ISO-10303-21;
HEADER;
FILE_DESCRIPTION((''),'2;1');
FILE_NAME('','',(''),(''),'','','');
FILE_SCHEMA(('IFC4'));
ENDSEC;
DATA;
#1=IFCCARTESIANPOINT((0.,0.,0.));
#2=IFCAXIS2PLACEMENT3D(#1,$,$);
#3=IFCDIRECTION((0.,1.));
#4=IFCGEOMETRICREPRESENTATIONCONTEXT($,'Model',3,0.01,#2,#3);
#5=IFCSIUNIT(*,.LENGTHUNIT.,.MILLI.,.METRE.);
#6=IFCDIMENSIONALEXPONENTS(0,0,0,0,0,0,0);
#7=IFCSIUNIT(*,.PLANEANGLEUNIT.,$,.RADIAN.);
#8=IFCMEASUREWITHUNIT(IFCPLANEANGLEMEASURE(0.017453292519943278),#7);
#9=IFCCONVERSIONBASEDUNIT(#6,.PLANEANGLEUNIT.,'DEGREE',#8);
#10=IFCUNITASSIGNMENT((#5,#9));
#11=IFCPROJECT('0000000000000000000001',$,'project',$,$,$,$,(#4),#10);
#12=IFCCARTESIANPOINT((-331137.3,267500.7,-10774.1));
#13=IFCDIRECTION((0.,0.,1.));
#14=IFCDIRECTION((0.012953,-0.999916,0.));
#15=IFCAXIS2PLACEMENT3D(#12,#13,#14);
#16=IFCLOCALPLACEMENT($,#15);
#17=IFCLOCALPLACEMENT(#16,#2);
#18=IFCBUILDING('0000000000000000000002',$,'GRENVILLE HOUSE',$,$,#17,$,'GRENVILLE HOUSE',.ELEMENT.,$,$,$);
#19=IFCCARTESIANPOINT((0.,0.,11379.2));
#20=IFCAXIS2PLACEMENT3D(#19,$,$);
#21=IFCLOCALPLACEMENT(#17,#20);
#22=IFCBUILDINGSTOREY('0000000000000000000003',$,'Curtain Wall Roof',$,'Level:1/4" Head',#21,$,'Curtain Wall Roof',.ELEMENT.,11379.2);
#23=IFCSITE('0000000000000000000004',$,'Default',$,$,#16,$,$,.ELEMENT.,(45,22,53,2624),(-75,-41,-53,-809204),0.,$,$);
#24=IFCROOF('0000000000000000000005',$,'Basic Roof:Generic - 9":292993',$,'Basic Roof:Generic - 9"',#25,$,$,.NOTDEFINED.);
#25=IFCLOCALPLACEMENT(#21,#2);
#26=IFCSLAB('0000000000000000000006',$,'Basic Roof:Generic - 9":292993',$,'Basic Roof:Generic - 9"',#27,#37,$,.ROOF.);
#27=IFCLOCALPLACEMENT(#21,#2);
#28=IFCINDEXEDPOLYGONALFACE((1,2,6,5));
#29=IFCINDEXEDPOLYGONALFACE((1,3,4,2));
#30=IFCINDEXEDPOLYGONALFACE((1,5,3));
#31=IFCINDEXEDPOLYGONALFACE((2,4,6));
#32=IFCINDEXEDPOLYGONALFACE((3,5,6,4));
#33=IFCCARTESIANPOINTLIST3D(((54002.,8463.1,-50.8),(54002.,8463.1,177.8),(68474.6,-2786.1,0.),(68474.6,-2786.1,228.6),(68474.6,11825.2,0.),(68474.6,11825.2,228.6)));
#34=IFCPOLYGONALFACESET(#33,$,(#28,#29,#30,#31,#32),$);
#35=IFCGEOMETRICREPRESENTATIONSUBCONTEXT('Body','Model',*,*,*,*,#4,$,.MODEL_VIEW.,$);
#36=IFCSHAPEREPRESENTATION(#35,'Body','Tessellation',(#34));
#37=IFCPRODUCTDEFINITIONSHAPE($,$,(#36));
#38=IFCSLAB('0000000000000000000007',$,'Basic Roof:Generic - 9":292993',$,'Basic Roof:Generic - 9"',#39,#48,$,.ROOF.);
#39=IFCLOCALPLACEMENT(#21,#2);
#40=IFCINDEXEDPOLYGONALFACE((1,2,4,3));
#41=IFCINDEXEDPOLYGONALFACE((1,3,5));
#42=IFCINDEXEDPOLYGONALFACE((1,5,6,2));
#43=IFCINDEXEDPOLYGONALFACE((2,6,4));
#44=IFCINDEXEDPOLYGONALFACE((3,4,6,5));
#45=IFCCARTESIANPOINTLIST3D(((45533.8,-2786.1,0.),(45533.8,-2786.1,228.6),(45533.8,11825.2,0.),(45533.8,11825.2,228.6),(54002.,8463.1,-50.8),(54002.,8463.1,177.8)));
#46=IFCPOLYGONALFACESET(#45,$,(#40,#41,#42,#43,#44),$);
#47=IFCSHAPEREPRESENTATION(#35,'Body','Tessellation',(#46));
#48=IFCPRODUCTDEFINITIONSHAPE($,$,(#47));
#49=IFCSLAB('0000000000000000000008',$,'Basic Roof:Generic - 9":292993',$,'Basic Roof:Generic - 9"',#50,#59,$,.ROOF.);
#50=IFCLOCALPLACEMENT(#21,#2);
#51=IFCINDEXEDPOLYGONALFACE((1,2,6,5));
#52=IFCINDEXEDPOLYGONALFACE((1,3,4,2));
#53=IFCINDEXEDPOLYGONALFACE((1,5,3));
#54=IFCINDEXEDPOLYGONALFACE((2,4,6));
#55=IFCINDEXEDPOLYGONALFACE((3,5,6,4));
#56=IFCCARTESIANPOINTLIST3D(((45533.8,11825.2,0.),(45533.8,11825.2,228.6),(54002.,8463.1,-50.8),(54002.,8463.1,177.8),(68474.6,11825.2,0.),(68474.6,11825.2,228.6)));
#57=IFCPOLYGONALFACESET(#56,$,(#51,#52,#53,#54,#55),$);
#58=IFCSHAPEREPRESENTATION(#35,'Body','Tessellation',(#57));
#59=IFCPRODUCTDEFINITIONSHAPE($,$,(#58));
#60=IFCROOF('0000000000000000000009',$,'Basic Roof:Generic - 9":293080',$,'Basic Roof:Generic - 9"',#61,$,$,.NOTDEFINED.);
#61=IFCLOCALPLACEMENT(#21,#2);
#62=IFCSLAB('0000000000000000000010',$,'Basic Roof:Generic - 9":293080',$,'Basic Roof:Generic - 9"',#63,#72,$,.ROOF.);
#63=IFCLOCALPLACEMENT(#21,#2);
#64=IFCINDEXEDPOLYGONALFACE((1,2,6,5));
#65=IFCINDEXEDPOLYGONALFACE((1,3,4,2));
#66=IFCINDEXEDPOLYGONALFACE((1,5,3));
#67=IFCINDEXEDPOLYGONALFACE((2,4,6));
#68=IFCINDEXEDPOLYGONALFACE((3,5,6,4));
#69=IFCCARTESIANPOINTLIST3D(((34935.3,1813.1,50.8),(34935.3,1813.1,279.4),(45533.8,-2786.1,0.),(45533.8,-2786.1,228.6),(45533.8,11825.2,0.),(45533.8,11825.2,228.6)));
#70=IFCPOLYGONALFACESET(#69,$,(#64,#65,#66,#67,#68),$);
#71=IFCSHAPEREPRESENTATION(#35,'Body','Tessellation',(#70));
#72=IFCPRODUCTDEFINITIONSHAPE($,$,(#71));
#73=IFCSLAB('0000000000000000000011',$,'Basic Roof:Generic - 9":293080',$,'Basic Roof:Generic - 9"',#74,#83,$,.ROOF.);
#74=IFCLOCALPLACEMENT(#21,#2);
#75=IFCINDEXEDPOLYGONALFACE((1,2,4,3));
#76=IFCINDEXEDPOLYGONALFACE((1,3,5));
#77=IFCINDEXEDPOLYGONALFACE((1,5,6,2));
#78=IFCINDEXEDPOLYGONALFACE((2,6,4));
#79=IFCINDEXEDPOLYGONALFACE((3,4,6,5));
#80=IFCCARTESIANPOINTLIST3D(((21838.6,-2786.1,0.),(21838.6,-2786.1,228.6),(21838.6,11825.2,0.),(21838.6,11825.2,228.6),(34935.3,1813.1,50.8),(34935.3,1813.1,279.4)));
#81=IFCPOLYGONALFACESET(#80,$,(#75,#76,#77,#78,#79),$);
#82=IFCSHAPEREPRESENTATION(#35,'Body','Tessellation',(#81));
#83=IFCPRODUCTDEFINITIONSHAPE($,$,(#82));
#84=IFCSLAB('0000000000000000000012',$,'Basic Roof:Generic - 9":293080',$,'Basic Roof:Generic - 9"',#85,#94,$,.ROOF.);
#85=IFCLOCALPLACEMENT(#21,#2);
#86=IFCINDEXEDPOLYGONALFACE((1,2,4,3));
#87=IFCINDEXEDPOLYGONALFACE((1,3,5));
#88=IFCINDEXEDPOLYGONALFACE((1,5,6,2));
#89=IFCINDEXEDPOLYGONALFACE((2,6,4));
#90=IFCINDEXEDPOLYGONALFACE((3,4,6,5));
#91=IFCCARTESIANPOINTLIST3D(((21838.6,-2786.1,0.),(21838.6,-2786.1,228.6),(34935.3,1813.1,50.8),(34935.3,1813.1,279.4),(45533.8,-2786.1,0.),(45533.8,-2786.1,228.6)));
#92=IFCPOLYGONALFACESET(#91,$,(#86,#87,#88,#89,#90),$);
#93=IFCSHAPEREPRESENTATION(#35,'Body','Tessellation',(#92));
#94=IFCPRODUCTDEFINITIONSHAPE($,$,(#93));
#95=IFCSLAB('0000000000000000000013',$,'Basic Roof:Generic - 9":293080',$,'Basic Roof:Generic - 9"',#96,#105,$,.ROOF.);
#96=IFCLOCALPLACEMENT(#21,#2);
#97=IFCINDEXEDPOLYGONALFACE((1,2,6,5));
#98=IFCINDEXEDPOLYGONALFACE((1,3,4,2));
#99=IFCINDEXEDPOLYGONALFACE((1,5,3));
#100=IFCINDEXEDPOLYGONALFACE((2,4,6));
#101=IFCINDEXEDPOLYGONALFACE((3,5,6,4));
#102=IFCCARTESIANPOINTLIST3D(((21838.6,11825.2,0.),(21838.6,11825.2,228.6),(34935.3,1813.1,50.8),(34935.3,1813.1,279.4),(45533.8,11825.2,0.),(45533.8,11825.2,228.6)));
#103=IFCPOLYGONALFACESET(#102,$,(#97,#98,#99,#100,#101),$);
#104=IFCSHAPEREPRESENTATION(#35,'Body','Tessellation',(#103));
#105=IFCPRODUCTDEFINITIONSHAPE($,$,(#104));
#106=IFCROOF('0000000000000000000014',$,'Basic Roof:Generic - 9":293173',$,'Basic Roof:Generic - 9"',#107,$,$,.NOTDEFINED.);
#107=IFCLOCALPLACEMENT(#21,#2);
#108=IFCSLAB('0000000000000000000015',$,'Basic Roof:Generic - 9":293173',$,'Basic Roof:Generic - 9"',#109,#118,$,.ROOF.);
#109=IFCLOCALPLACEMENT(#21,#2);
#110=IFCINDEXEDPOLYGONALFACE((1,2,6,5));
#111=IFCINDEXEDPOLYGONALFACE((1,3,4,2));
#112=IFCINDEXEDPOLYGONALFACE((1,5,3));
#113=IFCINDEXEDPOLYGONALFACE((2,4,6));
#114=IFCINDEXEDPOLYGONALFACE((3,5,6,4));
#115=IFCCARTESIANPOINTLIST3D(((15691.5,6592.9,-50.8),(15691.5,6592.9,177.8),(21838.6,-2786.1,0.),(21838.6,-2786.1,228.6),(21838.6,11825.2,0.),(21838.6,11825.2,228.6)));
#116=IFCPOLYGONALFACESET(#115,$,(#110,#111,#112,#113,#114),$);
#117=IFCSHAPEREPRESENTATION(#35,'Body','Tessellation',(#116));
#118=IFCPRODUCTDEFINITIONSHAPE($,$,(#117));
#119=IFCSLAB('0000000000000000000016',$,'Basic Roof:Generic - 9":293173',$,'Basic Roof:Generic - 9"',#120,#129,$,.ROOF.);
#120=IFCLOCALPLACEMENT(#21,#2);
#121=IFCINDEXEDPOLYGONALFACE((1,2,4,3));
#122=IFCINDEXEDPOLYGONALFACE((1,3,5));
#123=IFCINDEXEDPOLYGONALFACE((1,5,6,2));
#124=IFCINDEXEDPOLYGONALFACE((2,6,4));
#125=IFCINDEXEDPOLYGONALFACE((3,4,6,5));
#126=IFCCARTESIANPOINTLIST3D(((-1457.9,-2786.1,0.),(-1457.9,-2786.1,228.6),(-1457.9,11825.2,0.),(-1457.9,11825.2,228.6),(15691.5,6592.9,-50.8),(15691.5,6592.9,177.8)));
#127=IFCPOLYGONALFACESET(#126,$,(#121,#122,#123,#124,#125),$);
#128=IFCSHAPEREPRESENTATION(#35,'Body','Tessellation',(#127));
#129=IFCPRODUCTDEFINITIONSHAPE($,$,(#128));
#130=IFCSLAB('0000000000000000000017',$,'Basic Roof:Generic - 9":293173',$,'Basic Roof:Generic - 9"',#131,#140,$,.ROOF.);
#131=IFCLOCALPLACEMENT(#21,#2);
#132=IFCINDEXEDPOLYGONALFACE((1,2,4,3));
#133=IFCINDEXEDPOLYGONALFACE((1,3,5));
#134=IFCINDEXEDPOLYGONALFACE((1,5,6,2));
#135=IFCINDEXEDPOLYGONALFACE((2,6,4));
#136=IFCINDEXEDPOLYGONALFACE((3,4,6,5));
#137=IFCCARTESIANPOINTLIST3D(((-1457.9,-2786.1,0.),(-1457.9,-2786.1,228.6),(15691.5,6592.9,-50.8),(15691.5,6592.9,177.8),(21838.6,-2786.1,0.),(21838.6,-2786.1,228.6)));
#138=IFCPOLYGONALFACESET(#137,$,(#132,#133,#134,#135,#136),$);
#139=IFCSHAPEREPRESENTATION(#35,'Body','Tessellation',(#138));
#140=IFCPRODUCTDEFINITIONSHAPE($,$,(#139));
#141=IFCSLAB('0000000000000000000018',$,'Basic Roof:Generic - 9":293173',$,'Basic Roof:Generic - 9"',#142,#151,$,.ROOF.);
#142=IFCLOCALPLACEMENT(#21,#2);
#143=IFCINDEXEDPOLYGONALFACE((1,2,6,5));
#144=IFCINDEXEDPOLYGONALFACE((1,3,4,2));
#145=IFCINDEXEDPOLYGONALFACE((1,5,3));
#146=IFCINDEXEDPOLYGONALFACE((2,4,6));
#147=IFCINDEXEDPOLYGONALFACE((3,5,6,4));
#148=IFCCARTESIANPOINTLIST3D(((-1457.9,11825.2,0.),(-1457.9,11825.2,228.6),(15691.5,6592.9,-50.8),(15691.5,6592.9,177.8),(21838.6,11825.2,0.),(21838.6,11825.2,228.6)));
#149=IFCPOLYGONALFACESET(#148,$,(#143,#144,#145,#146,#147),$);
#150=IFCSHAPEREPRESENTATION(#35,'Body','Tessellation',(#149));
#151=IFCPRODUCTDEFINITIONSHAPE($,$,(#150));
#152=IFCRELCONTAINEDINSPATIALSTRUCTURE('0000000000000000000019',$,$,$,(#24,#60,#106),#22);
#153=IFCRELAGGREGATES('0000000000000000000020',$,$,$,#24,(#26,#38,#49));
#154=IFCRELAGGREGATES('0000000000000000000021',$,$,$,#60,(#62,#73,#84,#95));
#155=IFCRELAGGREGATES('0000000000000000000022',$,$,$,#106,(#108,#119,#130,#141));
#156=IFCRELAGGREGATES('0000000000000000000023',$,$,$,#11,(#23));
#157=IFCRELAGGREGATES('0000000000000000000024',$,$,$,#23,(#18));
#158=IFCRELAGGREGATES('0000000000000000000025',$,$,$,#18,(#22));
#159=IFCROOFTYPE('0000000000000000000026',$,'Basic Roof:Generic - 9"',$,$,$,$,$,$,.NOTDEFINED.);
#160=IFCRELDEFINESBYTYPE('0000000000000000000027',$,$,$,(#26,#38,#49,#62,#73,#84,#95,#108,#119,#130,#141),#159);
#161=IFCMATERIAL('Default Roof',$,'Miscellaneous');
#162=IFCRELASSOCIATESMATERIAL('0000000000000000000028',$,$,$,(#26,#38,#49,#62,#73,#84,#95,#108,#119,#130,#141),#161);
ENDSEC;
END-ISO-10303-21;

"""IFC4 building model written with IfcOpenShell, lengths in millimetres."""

from ifc_helpers import new_model, entity, si_unit, converted_unit, direction, frame, origin, place, context, subcontext, project, spatial, indexed_curve, outline, extrude, material, type_object, element, aggregate, save


model = new_model("IFC4")

# Units and contexts
model_context = context("Model", 3, precision=0.01, world=origin(), true_north=direction((0.0, 1.0)))
body_context = subcontext(model_context, "Body", "Model", "MODEL_VIEW")
ifc_project = project(units=[si_unit("LENGTHUNIT", "METRE", prefix="MILLI"), converted_unit("PLANEANGLEUNIT", "DEGREE", entity("IfcPlaneAngleMeasure", 0.017453292519943278), si_unit("PLANEANGLEUNIT", "RADIAN"), dimensions=[0, 0, 0, 0, 0, 0, 0])], contexts=[model_context])

# Site, building, storey
site_placement = place(None, frame((-331137.3, 267500.7, -10774.1), z_axis=(0.0, 0.0, 1.0), x_axis=(0.012953, -0.999916, 0.0)))
site = spatial("IfcSite", under=ifc_project, at=site_placement, Name="Default", CompositionType="ELEMENT", RefLatitude=(45, 22, 53, 2624), RefLongitude=(-75, -41, -53, -809204), RefElevation=0.0)
building_placement = place(site_placement, origin())
building = spatial("IfcBuilding", under=site, at=building_placement, Name="GRENVILLE HOUSE", LongName="GRENVILLE HOUSE", CompositionType="ELEMENT")
storey_placement = place(building_placement, frame((0.0, 0.0, 11379.2)))
storey = spatial("IfcBuildingStorey", under=building, at=storey_placement, Name="Curtain Wall Roof", ObjectType="Level:1/4\" Head", LongName="Curtain Wall Roof", CompositionType="ELEMENT", Elevation=11379.2)

# Roofs, slabs
roof_1_placement = place(storey_placement, frame((45533.8, -2786.1, -50.8)))
roof_1 = element("IfcRoof", 1, at=roof_1_placement, inside=storey, Name="Basic Roof:Generic - 9\":292993", ObjectType="Basic Roof:Generic - 9\"", PredefinedType="NOTDEFINED")
ifc_material = material(Name="Default Roof", Category="Miscellaneous")
roof_type = type_object("IfcRoofType", Name="Basic Roof:Generic - 9\"", PredefinedType="NOTDEFINED")
slab_1_placement = place(roof_1_placement, origin())
slab_1 = element("IfcSlab", 2, at=slab_1_placement, type_object=roof_type, material=ifc_material, Name="Basic Roof:Generic - 9\":292993", ObjectType="Basic Roof:Generic - 9\"", PredefinedType="ROOF", context=body_context, shape_type="SweptSolid", body=[
    extrude(outline(indexed_curve([(7236.4, -7305.7), (7236.4, 7305.7), (-7236.4, 3943.6), (7236.4, -7305.7)], self_intersect=False)), frame((15704.5, 7305.7, 25.4), z_axis=(-0.00351, 0.0, 0.999994), x_axis=(0.999994, 0.0, 0.00351)), (0.00351, 0.0, 0.999994), 228.6),
])
slab_2_placement = place(roof_1_placement, origin())
slab_2 = element("IfcSlab", 3, at=slab_2_placement, type_object=roof_type, material=ifc_material, Name="Basic Roof:Generic - 9\":292993", ObjectType="Basic Roof:Generic - 9\"", PredefinedType="ROOF", context=body_context, shape_type="SweptSolid", body=[
    extrude(outline(indexed_curve([(-4234.1, 7305.7), (-4234.1, -7305.7), (4234.1, 3943.6), (-4234.1, 7305.7)], self_intersect=False)), frame((4234.1, 7305.7, 25.4), z_axis=(0.005999, 0.0, 0.999982), x_axis=(0.999982, 0.0, -0.005999)), (-0.005999, 0.0, 0.999982), 228.6),
])
slab_3_placement = place(roof_1_placement, origin())
slab_3 = element("IfcSlab", 4, at=slab_3_placement, type_object=roof_type, material=ifc_material, Name="Basic Roof:Generic - 9\":292993", ObjectType="Basic Roof:Generic - 9\"", PredefinedType="ROOF", context=body_context, shape_type="SweptSolid", body=[
    extrude(outline(indexed_curve([(11470.4, 1681.2), (-11470.4, 1681.2), (-3002.2, -1681.2), (11470.4, 1681.2)], self_intersect=False)), frame((11470.4, 12930.3, 25.4), z_axis=(0.0, -0.015108, 0.999886), x_axis=(1.0, 0.0, 0.0)), (0.0, 0.015108, 0.999886), 228.6),
])
aggregate(roof_1, [slab_1, slab_2, slab_3])
roof_2_placement = place(storey_placement, frame((21838.6, -2786.1, 0.0)))
roof_2 = element("IfcRoof", 5, at=roof_2_placement, inside=storey, Name="Basic Roof:Generic - 9\":293080", ObjectType="Basic Roof:Generic - 9\"", PredefinedType="NOTDEFINED")
slab_4_placement = place(roof_2_placement, origin())
slab_4 = element("IfcSlab", 6, at=slab_4_placement, type_object=roof_type, material=ifc_material, Name="Basic Roof:Generic - 9\":293080", ObjectType="Basic Roof:Generic - 9\"", PredefinedType="ROOF", context=body_context, shape_type="SweptSolid", body=[
    extrude(outline(indexed_curve([(5299.3, -7305.7), (5299.3, 7305.7), (-5299.3, -2706.4), (5299.3, -7305.7)], self_intersect=False)), frame((18395.9, 7305.7, 25.4), z_axis=(0.004793, 0.0, 0.999989), x_axis=(0.999989, 0.0, -0.004793)), (-0.004793, 0.0, 0.999989), 228.6),
])
slab_5_placement = place(roof_2_placement, origin())
slab_5 = element("IfcSlab", 7, at=slab_5_placement, type_object=roof_type, material=ifc_material, Name="Basic Roof:Generic - 9\":293080", ObjectType="Basic Roof:Generic - 9\"", PredefinedType="ROOF", context=body_context, shape_type="SweptSolid", body=[
    extrude(outline(indexed_curve([(-6548.4, 7305.7), (-6548.4, -7305.7), (6548.4, -2706.4), (-6548.4, 7305.7)], self_intersect=False)), frame((6548.3, 7305.7, 25.4), z_axis=(-0.003879, 0.0, 0.999992), x_axis=(0.999992, 0.0, 0.003879)), (0.003879, 0.0, 0.999992), 228.6),
])
slab_6_placement = place(roof_2_placement, origin())
slab_6 = element("IfcSlab", 8, at=slab_6_placement, type_object=roof_type, material=ifc_material, Name="Basic Roof:Generic - 9\":293080", ObjectType="Basic Roof:Generic - 9\"", PredefinedType="ROOF", context=body_context, shape_type="SweptSolid", body=[
    extrude(outline(indexed_curve([(11847.6, 0.0), (1249.1, 4599.5), (-11847.6, 0.0), (11847.6, 0.0)], self_intersect=False)), frame((11847.6, 0.0, 0.0), z_axis=(0.0, -0.011045, 0.999939), x_axis=(1.0, 0.0, 0.0)), (0.0, 0.011045, 0.999939), 228.6),
])
slab_7_placement = place(roof_2_placement, origin())
slab_7 = element("IfcSlab", 9, at=slab_7_placement, type_object=roof_type, material=ifc_material, Name="Basic Roof:Generic - 9\":293080", ObjectType="Basic Roof:Generic - 9\"", PredefinedType="ROOF", context=body_context, shape_type="SweptSolid", body=[
    extrude(outline(indexed_curve([(11847.6, 5006.1), (-11847.6, 5006.1), (1249.1, -5006.1), (11847.6, 5006.1)], self_intersect=False)), frame((11847.6, 9605.3, 25.4), z_axis=(0.0, 0.005074, 0.999987), x_axis=(1.0, 0.0, 0.0)), (0.0, -0.005074, 0.999987), 228.6),
])
aggregate(roof_2, [slab_4, slab_5, slab_6, slab_7])
roof_3_placement = place(storey_placement, frame((-1457.9, -2786.1, -50.8)))
roof_3 = element("IfcRoof", 10, at=roof_3_placement, inside=storey, Name="Basic Roof:Generic - 9\":293173", ObjectType="Basic Roof:Generic - 9\"", PredefinedType="NOTDEFINED")
slab_8_placement = place(roof_3_placement, origin())
slab_8 = element("IfcSlab", 11, at=slab_8_placement, type_object=roof_type, material=ifc_material, Name="Basic Roof:Generic - 9\":293173", ObjectType="Basic Roof:Generic - 9\"", PredefinedType="ROOF", context=body_context, shape_type="SweptSolid", body=[
    extrude(outline(indexed_curve([(3073.7, -7305.7), (3073.7, 7305.7), (-3073.7, 2073.4), (3073.7, -7305.7)], self_intersect=False)), frame((20223.0, 7305.7, 25.4), z_axis=(-0.008264, 0.0, 0.999966), x_axis=(0.999966, 0.0, 0.008264)), (0.008264, 0.0, 0.999966), 228.6),
])
slab_9_placement = place(roof_3_placement, origin())
slab_9 = element("IfcSlab", 12, at=slab_9_placement, type_object=roof_type, material=ifc_material, Name="Basic Roof:Generic - 9\":293173", ObjectType="Basic Roof:Generic - 9\"", PredefinedType="ROOF", context=body_context, shape_type="SweptSolid", body=[
    extrude(outline(indexed_curve([(-8574.7, 7305.7), (-8574.7, -7305.7), (8574.7, 2073.4), (-8574.7, 7305.7)], self_intersect=False)), frame((8574.7, 7305.7, 25.4), z_axis=(0.002962, 0.0, 0.999996), x_axis=(0.999996, 0.0, -0.002962)), (-0.002962, 0.0, 0.999996), 228.6),
])
slab_10_placement = place(roof_3_placement, origin())
slab_10 = element("IfcSlab", 13, at=slab_10_placement, type_object=roof_type, material=ifc_material, Name="Basic Roof:Generic - 9\":293173", ObjectType="Basic Roof:Generic - 9\"", PredefinedType="ROOF", context=body_context, shape_type="SweptSolid", body=[
    extrude(outline(indexed_curve([(11648.3, 0.0), (5501.1, 9379.2), (-11648.3, 0.0), (11648.3, 0.0)], self_intersect=False)), frame((11648.3, 0.0, 50.8), z_axis=(0.0, 0.005416, 0.999985), x_axis=(1.0, 0.0, 0.0)), (0.0, -0.005416, 0.999985), 228.6),
])
slab_11_placement = place(roof_3_placement, origin())
slab_11 = element("IfcSlab", 14, at=slab_11_placement, type_object=roof_type, material=ifc_material, Name="Basic Roof:Generic - 9\":293173", ObjectType="Basic Roof:Generic - 9\"", PredefinedType="ROOF", context=body_context, shape_type="SweptSolid", body=[
    extrude(outline(indexed_curve([(11648.3, 2616.3), (-11648.3, 2616.3), (5501.1, -2616.3), (11648.3, 2616.3)], self_intersect=False)), frame((11648.3, 11995.2, 25.4), z_axis=(0.0, -0.009709, 0.999953), x_axis=(1.0, 0.0, 0.0)), (0.0, 0.009709, 0.999953), 228.6),
])
aggregate(roof_3, [slab_8, slab_9, slab_10, slab_11])

save(model, "model.ifc")
